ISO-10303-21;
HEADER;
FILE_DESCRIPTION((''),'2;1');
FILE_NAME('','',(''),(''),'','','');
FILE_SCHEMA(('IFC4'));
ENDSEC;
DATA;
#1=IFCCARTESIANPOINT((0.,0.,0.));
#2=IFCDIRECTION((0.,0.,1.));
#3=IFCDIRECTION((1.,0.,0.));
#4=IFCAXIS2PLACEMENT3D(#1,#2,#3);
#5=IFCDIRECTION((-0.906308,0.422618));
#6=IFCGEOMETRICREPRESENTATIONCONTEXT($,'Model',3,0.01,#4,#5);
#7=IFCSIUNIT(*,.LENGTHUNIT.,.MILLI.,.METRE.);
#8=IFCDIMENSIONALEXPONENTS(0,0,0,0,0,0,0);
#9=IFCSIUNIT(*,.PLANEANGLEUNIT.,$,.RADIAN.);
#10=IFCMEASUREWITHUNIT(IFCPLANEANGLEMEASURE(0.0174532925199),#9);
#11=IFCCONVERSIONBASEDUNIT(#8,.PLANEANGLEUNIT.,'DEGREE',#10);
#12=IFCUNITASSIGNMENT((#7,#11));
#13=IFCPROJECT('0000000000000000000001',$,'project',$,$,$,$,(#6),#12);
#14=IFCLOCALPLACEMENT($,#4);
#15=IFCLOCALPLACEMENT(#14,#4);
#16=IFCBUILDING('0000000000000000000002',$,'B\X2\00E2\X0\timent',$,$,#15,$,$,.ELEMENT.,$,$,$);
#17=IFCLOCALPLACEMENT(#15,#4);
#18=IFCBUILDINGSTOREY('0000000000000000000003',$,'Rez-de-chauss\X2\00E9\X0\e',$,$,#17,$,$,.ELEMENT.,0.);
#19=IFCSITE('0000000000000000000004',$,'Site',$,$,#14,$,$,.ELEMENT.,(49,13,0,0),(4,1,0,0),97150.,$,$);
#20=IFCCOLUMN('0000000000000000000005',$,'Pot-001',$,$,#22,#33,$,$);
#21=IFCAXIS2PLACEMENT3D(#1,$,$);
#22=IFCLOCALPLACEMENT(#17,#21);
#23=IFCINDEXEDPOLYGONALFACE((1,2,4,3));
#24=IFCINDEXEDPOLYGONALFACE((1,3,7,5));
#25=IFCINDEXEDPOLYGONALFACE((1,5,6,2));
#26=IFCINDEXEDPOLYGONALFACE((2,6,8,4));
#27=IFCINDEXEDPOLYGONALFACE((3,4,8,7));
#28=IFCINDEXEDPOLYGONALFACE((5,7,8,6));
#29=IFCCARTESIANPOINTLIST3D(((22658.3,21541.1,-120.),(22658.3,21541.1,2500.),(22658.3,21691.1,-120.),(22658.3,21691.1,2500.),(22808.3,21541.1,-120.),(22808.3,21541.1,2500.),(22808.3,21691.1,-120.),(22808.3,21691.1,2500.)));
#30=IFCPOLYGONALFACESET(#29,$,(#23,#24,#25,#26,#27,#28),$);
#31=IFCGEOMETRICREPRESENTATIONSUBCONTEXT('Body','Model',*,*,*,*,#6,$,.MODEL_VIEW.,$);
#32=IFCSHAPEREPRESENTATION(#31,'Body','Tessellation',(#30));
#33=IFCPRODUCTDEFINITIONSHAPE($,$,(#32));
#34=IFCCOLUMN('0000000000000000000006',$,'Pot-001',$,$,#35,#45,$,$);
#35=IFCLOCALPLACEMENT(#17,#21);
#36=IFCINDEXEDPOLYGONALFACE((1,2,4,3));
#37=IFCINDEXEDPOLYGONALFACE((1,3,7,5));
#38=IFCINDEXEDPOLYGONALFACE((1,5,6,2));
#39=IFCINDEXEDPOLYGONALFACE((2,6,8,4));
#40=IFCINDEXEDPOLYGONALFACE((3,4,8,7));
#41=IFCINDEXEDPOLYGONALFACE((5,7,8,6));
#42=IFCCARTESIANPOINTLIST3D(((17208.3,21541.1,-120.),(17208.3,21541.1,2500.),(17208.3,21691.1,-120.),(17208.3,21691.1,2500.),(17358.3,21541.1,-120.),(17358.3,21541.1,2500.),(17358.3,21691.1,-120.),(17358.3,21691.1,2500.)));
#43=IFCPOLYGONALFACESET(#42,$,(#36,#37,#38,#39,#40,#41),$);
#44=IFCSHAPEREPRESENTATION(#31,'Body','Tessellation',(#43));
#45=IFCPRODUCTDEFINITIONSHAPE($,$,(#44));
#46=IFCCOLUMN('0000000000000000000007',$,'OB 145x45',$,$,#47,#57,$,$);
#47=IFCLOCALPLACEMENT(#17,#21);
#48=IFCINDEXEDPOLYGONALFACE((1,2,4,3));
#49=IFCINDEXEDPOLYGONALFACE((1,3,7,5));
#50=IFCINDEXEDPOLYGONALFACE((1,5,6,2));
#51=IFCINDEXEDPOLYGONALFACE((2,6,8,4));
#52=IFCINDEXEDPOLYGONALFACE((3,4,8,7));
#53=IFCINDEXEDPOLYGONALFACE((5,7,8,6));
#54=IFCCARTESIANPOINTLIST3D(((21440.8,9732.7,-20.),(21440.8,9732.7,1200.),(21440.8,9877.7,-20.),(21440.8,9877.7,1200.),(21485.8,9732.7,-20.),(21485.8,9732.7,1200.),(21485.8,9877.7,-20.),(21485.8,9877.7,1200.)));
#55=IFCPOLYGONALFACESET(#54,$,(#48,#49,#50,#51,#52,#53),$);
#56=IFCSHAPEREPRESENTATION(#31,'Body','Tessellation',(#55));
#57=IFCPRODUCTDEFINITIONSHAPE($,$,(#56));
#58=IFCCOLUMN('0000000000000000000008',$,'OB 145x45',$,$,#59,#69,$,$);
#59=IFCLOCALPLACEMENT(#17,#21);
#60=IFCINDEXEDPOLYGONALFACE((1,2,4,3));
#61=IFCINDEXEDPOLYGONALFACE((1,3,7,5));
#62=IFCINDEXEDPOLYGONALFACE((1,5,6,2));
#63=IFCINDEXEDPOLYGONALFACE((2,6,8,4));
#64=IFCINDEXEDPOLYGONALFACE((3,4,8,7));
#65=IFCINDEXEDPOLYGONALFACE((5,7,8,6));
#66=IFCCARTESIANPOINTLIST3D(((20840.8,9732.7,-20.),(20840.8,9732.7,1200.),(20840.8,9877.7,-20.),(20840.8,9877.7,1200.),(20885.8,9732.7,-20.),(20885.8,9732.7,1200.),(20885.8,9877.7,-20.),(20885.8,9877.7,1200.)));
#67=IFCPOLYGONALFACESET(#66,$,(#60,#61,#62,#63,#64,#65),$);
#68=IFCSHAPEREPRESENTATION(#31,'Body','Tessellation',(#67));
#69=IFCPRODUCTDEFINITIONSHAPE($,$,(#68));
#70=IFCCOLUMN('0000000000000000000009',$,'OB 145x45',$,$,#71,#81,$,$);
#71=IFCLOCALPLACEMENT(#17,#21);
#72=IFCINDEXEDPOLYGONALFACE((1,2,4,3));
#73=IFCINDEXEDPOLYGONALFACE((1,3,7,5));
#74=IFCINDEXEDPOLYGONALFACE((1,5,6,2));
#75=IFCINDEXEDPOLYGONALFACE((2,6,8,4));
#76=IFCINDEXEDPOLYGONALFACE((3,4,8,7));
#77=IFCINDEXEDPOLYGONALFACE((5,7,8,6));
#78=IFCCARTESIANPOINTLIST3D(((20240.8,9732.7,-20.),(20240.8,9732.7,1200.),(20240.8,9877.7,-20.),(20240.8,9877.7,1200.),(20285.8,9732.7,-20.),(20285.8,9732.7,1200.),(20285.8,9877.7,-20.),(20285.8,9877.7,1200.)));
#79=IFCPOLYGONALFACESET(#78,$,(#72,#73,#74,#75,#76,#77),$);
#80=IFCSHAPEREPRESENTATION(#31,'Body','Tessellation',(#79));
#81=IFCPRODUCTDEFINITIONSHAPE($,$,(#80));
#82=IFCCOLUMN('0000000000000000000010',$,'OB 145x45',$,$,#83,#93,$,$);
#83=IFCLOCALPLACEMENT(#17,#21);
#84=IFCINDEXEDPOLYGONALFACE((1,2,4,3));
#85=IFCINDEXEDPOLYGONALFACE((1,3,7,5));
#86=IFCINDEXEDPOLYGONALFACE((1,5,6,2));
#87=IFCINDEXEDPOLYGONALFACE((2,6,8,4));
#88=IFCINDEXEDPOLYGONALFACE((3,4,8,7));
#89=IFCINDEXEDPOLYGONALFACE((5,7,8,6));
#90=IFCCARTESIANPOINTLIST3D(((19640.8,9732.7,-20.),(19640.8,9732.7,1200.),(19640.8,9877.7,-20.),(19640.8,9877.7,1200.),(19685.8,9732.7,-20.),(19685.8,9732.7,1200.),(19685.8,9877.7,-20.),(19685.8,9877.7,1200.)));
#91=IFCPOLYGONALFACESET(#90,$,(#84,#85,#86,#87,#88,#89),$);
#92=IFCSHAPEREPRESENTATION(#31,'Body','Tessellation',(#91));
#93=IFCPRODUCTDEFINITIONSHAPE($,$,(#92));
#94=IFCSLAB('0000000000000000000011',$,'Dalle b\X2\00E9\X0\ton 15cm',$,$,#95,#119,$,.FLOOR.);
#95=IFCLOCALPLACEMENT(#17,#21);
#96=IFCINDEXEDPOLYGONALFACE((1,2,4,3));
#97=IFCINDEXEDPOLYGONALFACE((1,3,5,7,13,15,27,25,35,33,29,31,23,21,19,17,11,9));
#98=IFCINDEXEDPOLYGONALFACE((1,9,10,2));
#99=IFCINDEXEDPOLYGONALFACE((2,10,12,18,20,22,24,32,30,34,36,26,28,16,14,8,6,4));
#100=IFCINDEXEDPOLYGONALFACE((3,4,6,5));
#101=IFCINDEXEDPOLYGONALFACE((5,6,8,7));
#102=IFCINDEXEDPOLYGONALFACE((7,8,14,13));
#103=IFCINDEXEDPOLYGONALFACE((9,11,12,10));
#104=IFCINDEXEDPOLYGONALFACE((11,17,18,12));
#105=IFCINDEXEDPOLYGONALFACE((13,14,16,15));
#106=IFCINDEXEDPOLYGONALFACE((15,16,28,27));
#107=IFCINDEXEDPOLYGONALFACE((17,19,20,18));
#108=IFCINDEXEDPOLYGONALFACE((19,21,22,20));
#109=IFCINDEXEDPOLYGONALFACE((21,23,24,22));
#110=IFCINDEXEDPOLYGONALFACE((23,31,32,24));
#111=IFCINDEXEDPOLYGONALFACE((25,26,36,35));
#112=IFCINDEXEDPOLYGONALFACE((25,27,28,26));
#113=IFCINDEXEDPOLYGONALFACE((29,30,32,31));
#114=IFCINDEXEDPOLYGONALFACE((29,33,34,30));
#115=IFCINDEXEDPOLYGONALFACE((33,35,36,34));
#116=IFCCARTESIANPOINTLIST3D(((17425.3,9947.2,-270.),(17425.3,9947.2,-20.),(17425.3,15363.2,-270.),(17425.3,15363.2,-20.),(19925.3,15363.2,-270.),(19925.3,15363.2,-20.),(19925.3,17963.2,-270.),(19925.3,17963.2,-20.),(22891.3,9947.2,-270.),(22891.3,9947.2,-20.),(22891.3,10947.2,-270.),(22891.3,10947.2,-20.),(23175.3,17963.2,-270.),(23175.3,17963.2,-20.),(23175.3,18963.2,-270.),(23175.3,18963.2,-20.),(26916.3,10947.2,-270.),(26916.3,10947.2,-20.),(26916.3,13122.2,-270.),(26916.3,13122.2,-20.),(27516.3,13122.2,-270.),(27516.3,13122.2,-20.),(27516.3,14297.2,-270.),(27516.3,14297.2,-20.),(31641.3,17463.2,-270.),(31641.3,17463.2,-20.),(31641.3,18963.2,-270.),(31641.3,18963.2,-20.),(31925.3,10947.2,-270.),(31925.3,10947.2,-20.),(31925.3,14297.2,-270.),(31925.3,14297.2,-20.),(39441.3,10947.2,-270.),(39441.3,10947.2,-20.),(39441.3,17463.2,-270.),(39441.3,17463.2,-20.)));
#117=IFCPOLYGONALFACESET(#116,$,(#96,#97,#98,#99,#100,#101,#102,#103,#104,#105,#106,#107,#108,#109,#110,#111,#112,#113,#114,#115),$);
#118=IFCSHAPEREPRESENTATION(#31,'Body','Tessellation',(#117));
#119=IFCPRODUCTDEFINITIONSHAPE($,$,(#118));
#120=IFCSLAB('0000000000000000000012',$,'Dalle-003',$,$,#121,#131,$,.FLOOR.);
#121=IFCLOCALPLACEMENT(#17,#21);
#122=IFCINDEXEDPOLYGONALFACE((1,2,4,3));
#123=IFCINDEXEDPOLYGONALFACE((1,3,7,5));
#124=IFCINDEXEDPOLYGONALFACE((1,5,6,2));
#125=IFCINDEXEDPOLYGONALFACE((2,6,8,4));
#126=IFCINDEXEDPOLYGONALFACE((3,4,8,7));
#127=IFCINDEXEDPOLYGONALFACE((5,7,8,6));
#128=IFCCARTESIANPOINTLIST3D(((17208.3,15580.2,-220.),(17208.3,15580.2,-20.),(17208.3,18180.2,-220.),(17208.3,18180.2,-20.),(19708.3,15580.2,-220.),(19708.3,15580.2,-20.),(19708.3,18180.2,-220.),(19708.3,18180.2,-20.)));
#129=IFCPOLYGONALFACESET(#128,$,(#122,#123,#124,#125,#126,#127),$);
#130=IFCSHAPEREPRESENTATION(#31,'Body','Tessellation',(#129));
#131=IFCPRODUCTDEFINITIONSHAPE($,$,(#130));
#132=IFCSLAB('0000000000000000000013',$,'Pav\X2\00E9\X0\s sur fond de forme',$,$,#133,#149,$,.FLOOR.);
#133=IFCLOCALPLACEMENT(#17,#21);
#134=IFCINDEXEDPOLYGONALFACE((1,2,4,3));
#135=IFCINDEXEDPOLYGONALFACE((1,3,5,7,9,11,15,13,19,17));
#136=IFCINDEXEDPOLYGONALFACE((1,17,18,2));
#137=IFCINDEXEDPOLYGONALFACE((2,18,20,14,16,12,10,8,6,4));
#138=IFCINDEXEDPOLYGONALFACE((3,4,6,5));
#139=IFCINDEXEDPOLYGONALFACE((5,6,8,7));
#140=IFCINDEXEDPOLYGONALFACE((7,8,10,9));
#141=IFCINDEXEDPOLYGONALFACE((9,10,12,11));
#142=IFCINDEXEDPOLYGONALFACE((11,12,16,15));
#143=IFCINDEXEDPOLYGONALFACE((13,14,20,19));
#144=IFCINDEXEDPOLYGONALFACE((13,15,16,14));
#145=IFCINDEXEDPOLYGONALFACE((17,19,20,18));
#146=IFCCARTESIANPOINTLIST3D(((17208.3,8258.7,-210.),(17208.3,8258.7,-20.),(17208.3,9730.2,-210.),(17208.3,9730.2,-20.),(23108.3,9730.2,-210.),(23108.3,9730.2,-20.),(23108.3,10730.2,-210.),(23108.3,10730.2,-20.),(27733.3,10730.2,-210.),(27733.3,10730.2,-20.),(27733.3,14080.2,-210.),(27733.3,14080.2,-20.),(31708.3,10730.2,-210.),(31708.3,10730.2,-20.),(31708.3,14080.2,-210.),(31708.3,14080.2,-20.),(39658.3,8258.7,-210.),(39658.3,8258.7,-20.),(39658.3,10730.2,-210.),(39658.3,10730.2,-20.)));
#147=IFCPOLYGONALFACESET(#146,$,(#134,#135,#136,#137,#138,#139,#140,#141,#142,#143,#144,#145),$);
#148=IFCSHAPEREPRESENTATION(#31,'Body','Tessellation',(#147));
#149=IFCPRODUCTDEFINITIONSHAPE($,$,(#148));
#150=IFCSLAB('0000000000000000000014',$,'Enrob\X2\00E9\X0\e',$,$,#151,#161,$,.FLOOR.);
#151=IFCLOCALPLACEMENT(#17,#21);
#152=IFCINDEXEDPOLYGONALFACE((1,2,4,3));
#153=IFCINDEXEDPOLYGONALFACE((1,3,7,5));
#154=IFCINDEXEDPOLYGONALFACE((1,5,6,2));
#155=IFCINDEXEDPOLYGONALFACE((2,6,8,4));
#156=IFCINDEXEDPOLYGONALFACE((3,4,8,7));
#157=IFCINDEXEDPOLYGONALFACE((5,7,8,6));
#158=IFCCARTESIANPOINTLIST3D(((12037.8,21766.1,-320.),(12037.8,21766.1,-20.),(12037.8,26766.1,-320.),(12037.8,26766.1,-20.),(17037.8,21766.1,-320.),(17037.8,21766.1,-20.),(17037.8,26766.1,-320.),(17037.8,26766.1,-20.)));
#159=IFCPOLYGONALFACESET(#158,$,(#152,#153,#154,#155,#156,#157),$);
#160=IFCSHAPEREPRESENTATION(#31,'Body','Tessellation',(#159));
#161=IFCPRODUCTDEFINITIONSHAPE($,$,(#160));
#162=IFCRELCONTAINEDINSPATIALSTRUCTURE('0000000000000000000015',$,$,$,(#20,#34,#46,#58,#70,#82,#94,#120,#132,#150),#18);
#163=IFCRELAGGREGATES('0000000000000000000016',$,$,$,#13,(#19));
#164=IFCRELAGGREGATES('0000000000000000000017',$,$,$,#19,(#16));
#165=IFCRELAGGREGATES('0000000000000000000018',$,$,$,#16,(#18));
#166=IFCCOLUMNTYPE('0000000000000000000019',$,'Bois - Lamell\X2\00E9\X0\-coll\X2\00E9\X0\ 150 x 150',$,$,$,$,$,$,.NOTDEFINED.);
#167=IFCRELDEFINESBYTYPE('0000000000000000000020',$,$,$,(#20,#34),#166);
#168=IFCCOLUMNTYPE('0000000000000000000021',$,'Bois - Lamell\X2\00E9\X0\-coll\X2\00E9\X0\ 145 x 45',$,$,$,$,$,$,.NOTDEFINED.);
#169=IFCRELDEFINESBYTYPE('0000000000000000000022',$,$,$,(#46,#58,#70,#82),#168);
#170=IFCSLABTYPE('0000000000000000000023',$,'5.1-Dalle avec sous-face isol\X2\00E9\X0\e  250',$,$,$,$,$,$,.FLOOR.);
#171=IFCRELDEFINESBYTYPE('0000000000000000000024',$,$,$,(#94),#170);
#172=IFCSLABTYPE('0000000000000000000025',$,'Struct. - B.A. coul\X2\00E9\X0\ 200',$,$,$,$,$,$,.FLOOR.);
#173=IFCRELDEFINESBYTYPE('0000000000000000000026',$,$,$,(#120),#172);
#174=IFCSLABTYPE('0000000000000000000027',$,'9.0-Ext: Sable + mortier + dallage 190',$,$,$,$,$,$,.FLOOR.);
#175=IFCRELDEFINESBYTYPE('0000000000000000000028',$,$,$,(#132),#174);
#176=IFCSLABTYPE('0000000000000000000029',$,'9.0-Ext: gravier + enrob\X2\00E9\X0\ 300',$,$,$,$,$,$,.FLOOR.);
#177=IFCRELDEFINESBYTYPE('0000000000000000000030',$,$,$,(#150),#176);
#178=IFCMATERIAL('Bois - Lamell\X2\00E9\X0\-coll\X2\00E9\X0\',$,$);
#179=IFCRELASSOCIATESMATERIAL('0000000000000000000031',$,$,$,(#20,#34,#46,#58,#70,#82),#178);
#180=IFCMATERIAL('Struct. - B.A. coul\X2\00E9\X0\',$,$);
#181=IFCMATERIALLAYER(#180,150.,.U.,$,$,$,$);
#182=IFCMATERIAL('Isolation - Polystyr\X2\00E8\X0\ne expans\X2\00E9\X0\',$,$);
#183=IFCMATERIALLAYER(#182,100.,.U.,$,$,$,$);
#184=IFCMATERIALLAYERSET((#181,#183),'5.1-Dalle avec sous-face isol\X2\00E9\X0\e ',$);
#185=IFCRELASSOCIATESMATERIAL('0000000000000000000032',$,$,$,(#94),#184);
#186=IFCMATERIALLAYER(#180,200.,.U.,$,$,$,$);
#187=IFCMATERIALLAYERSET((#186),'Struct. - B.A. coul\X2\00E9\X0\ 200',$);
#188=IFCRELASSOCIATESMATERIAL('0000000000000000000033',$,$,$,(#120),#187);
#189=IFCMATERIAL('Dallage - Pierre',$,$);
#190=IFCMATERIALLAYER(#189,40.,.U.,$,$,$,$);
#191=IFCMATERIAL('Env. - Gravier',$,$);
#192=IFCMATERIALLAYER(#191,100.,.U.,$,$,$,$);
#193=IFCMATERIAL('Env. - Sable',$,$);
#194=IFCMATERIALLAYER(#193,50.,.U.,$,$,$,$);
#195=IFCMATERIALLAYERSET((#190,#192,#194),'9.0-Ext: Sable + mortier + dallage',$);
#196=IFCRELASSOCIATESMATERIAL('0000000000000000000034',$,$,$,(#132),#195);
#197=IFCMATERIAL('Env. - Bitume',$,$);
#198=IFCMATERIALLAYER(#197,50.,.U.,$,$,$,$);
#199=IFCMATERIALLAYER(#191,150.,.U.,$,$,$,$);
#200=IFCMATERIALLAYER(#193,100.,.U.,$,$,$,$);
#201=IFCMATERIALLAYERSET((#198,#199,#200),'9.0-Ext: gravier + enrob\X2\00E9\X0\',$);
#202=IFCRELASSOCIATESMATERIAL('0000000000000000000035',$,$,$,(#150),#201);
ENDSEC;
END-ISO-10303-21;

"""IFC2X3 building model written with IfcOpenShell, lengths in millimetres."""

from ifc_helpers import new_model, entity, si_unit, converted_unit, direction, frame, origin_with_axes, origin_2d_with_axis, place, context, subcontext, project, spatial, polyline, rectangle, outline, extrude, material, layer, layer_set, layer_usage, type_object, element, save


model = new_model("IFC2X3")

# Units and contexts
model_context = context("Model", 3, precision=0.01, world=origin_with_axes(), true_north=direction((-0.906308, 0.422618)))
body_context = subcontext(model_context, "Body", "Model", "MODEL_VIEW")
ifc_project = project(units=[si_unit("LENGTHUNIT", "METRE", prefix="MILLI"), converted_unit("PLANEANGLEUNIT", "DEGREE", entity("IfcPlaneAngleMeasure", 0.0174532925199), si_unit("PLANEANGLEUNIT", "RADIAN"), dimensions=[0, 0, 0, 0, 0, 0, 0])], contexts=[model_context])

# Site, building, storey
site_placement = place(None, origin_with_axes())
site = spatial("IfcSite", under=ifc_project, at=site_placement, Name="Site", CompositionType="ELEMENT", RefLatitude=(49, 13, 0, 0), RefLongitude=(4, 1, 0, 0), RefElevation=97150.0)
building_placement = place(site_placement, origin_with_axes())
building = spatial("IfcBuilding", under=site, at=building_placement, Name="Bâtiment", CompositionType="ELEMENT")
storey_placement = place(building_placement, origin_with_axes())
storey = spatial("IfcBuildingStorey", under=building, at=storey_placement, Name="Rez-de-chaussée", CompositionType="ELEMENT", Elevation=0.0)

# Columns
ifc_material_1 = material(Name="Bois - Lamellé-collé")
column_type_1 = type_object("IfcColumnType", Name="Bois - Lamellé-collé 150 x 150", PredefinedType="NOTDEFINED")
for number, where, z_axis, x_axis, name in (
    (1, (22733.3, 21616.1, -120.0), (0.0, 0.0, 1.0), (1.0, 0.0, 0.0), "Pot-001"),
    (2, (17283.3, 21616.1, -120.0), (0.0, 0.0, 1.0), (1.0, 0.0, 0.0), "Pot-001"),
):
    element("IfcColumn", number, at=place(storey_placement, frame(where, z_axis=z_axis, x_axis=x_axis)), inside=storey, type_object=column_type_1, material=ifc_material_1, Name=name, context=body_context, shape_type="SweptSolid", body=[
        extrude(rectangle(XDim=150.0, YDim=150.0, at=origin_2d_with_axis()), origin_with_axes(), (0.0, 0.0, 1.0), 2620.0),
    ])
column_type_2 = type_object("IfcColumnType", Name="Bois - Lamellé-collé 145 x 45", PredefinedType="NOTDEFINED")
for number, where, z_axis, x_axis, name in (
    (3, (21463.3, 9805.2, -20.0), (0.0, 0.0, 1.0), (0.0, -1.0, 0.0), "OB 145x45"),
    (4, (20863.3, 9805.2, -20.0), (0.0, 0.0, 1.0), (0.0, -1.0, 0.0), "OB 145x45"),
    (5, (20263.3, 9805.2, -20.0), (0.0, 0.0, 1.0), (0.0, -1.0, 0.0), "OB 145x45"),
    (6, (19663.3, 9805.2, -20.0), (0.0, 0.0, 1.0), (0.0, -1.0, 0.0), "OB 145x45"),
):
    element("IfcColumn", number, at=place(storey_placement, frame(where, z_axis=z_axis, x_axis=x_axis)), inside=storey, type_object=column_type_2, material=ifc_material_1, Name=name, context=body_context, shape_type="SweptSolid", body=[
        extrude(rectangle(XDim=145.0, YDim=45.0, at=origin_2d_with_axis()), frame((0.0, 0.0, 0.0), z_axis=(0.0, 0.0, -1.0), x_axis=(-1.0, 0.0, 0.0)), (0.0, 0.0, -1.0), 1220.0),
    ])

# Slabs
ifc_material_2 = material(Name="Struct. - B.A. coulé")
ifc_layer_1 = layer(ifc_material_2, 150.0, ventilated="UNKNOWN")
ifc_material_3 = material(Name="Isolation - Polystyrène expansé")
ifc_layer_2 = layer(ifc_material_3, 100.0, ventilated="UNKNOWN")
ifc_layer_set_1 = layer_set([ifc_layer_1, ifc_layer_2], Name="5.1-Dalle avec sous-face isolée ")
ifc_layer_usage_1 = layer_usage(ifc_layer_set_1, "AXIS3", "NEGATIVE", 250.0)
slab_type_1 = type_object("IfcSlabType", Name="5.1-Dalle avec sous-face isolée  250", PredefinedType="FLOOR")
slab_1_placement = place(storey_placement, frame((17425.3, 9947.2, -20.0), z_axis=(0.0, 0.0, 1.0), x_axis=(1.0, 0.0, 0.0)))
element("IfcSlab", 7, at=slab_1_placement, inside=storey, type_object=slab_type_1, material=ifc_layer_usage_1, Name="Dalle béton 15cm", PredefinedType="FLOOR", context=body_context, shape_type="SweptSolid", body=[
    extrude(outline(polyline([(0.0, 0.0), (5466.0, 0.0), (5466.0, 1000.0), (9491.0, 1000.0), (9491.0, 3175.0), (10091.0, 3175.0), (10091.0, 4350.0), (14500.0, 4350.0), (14500.0, 1000.0), (22016.0, 1000.0), (22016.0, 7516.0), (14216.0, 7516.0), (14216.0, 9016.0), (5750.0, 9016.0), (5750.0, 8016.0), (2500.0, 8016.0), (2500.0, 5416.0), (0.0, 5416.0), (0.0, 0.0)])), frame((0.0, 0.0, -250.0), z_axis=(0.0, 0.0, 1.0), x_axis=(1.0, 0.0, 0.0)), (0.0, 0.0, 1.0), 250.0),
])
ifc_layer_3 = layer(ifc_material_2, 200.0, ventilated="UNKNOWN")
ifc_layer_set_2 = layer_set([ifc_layer_3], Name="Struct. - B.A. coulé 200")
ifc_layer_usage_2 = layer_usage(ifc_layer_set_2, "AXIS3", "NEGATIVE", 200.0)
slab_type_2 = type_object("IfcSlabType", Name="Struct. - B.A. coulé 200", PredefinedType="FLOOR")
slab_2_placement = place(storey_placement, frame((17208.3, 15580.2, -20.0), z_axis=(0.0, 0.0, 1.0), x_axis=(1.0, 0.0, 0.0)))
element("IfcSlab", 8, at=slab_2_placement, inside=storey, type_object=slab_type_2, material=ifc_layer_usage_2, Name="Dalle-003", PredefinedType="FLOOR", context=body_context, shape_type="SweptSolid", body=[
    extrude(outline(polyline([(0.0, 0.0), (2500.0, 0.0), (2500.0, 2600.0), (0.0, 2600.0), (0.0, 0.0)])), frame((0.0, 0.0, -200.0), z_axis=(0.0, 0.0, 1.0), x_axis=(1.0, 0.0, 0.0)), (0.0, 0.0, 1.0), 200.0),
])
ifc_material_4 = material(Name="Dallage - Pierre")
ifc_layer_4 = layer(ifc_material_4, 40.0, ventilated="UNKNOWN")
ifc_material_5 = material(Name="Env. - Gravier")
ifc_layer_5 = layer(ifc_material_5, 100.0, ventilated="UNKNOWN")
ifc_material_6 = material(Name="Env. - Sable")
ifc_layer_6 = layer(ifc_material_6, 50.0, ventilated="UNKNOWN")
ifc_layer_set_3 = layer_set([ifc_layer_4, ifc_layer_5, ifc_layer_6], Name="9.0-Ext: Sable + mortier + dallage")
slab_type_3 = type_object("IfcSlabType", Name="9.0-Ext: Sable + mortier + dallage 190", PredefinedType="FLOOR")
ifc_layer_usage_3 = layer_usage(ifc_layer_set_3, "AXIS3", "NEGATIVE", 190.0)
slab_3_placement = place(storey_placement, frame((17208.3, 8258.7, -20.0), z_axis=(0.0, 0.0, 1.0), x_axis=(1.0, 0.0, 0.0)))
element("IfcSlab", 9, at=slab_3_placement, inside=storey, type_object=slab_type_3, material=ifc_layer_usage_3, Name="Pavés sur fond de forme", PredefinedType="FLOOR", context=body_context, shape_type="SweptSolid", body=[
    extrude(outline(polyline([(0.0, 0.0), (22450.0, 0.0), (22450.0, 2471.5), (14500.0, 2471.5), (14500.0, 5821.5), (10525.0, 5821.5), (10525.0, 2471.5), (5900.0, 2471.5), (5900.0, 1471.5), (0.0, 1471.5), (0.0, 0.0)])), frame((0.0, 0.0, -190.0), z_axis=(0.0, 0.0, 1.0), x_axis=(1.0, 0.0, 0.0)), (0.0, 0.0, 1.0), 190.0),
])
ifc_material_7 = material(Name="Env. - Bitume")
ifc_layer_7 = layer(ifc_material_7, 50.0, ventilated="UNKNOWN")
ifc_layer_8 = layer(ifc_material_5, 150.0, ventilated="UNKNOWN")
ifc_layer_9 = layer(ifc_material_6, 100.0, ventilated="UNKNOWN")
ifc_layer_set_4 = layer_set([ifc_layer_7, ifc_layer_8, ifc_layer_9], Name="9.0-Ext: gravier + enrobé")
slab_type_4 = type_object("IfcSlabType", Name="9.0-Ext: gravier + enrobé 300", PredefinedType="FLOOR")
ifc_layer_usage_4 = layer_usage(ifc_layer_set_4, "AXIS3", "NEGATIVE", 300.0)
slab_4_placement = place(storey_placement, frame((17037.8, 21766.1, -20.0), z_axis=(0.0, 0.0, 1.0), x_axis=(1.0, 0.0, 0.0)))
element("IfcSlab", 10, at=slab_4_placement, inside=storey, type_object=slab_type_4, material=ifc_layer_usage_4, Name="Enrobée", PredefinedType="FLOOR", context=body_context, shape_type="SweptSolid", body=[
    extrude(outline(polyline([(0.0, 0.0), (0.0, 5000.0), (-5000.0, 5000.0), (-5000.0, 0.0), (0.0, 0.0)])), frame((0.0, 0.0, -300.0), z_axis=(0.0, 0.0, 1.0), x_axis=(1.0, 0.0, 0.0)), (0.0, 0.0, 1.0), 300.0),
])

save(model, "model.ifc")
